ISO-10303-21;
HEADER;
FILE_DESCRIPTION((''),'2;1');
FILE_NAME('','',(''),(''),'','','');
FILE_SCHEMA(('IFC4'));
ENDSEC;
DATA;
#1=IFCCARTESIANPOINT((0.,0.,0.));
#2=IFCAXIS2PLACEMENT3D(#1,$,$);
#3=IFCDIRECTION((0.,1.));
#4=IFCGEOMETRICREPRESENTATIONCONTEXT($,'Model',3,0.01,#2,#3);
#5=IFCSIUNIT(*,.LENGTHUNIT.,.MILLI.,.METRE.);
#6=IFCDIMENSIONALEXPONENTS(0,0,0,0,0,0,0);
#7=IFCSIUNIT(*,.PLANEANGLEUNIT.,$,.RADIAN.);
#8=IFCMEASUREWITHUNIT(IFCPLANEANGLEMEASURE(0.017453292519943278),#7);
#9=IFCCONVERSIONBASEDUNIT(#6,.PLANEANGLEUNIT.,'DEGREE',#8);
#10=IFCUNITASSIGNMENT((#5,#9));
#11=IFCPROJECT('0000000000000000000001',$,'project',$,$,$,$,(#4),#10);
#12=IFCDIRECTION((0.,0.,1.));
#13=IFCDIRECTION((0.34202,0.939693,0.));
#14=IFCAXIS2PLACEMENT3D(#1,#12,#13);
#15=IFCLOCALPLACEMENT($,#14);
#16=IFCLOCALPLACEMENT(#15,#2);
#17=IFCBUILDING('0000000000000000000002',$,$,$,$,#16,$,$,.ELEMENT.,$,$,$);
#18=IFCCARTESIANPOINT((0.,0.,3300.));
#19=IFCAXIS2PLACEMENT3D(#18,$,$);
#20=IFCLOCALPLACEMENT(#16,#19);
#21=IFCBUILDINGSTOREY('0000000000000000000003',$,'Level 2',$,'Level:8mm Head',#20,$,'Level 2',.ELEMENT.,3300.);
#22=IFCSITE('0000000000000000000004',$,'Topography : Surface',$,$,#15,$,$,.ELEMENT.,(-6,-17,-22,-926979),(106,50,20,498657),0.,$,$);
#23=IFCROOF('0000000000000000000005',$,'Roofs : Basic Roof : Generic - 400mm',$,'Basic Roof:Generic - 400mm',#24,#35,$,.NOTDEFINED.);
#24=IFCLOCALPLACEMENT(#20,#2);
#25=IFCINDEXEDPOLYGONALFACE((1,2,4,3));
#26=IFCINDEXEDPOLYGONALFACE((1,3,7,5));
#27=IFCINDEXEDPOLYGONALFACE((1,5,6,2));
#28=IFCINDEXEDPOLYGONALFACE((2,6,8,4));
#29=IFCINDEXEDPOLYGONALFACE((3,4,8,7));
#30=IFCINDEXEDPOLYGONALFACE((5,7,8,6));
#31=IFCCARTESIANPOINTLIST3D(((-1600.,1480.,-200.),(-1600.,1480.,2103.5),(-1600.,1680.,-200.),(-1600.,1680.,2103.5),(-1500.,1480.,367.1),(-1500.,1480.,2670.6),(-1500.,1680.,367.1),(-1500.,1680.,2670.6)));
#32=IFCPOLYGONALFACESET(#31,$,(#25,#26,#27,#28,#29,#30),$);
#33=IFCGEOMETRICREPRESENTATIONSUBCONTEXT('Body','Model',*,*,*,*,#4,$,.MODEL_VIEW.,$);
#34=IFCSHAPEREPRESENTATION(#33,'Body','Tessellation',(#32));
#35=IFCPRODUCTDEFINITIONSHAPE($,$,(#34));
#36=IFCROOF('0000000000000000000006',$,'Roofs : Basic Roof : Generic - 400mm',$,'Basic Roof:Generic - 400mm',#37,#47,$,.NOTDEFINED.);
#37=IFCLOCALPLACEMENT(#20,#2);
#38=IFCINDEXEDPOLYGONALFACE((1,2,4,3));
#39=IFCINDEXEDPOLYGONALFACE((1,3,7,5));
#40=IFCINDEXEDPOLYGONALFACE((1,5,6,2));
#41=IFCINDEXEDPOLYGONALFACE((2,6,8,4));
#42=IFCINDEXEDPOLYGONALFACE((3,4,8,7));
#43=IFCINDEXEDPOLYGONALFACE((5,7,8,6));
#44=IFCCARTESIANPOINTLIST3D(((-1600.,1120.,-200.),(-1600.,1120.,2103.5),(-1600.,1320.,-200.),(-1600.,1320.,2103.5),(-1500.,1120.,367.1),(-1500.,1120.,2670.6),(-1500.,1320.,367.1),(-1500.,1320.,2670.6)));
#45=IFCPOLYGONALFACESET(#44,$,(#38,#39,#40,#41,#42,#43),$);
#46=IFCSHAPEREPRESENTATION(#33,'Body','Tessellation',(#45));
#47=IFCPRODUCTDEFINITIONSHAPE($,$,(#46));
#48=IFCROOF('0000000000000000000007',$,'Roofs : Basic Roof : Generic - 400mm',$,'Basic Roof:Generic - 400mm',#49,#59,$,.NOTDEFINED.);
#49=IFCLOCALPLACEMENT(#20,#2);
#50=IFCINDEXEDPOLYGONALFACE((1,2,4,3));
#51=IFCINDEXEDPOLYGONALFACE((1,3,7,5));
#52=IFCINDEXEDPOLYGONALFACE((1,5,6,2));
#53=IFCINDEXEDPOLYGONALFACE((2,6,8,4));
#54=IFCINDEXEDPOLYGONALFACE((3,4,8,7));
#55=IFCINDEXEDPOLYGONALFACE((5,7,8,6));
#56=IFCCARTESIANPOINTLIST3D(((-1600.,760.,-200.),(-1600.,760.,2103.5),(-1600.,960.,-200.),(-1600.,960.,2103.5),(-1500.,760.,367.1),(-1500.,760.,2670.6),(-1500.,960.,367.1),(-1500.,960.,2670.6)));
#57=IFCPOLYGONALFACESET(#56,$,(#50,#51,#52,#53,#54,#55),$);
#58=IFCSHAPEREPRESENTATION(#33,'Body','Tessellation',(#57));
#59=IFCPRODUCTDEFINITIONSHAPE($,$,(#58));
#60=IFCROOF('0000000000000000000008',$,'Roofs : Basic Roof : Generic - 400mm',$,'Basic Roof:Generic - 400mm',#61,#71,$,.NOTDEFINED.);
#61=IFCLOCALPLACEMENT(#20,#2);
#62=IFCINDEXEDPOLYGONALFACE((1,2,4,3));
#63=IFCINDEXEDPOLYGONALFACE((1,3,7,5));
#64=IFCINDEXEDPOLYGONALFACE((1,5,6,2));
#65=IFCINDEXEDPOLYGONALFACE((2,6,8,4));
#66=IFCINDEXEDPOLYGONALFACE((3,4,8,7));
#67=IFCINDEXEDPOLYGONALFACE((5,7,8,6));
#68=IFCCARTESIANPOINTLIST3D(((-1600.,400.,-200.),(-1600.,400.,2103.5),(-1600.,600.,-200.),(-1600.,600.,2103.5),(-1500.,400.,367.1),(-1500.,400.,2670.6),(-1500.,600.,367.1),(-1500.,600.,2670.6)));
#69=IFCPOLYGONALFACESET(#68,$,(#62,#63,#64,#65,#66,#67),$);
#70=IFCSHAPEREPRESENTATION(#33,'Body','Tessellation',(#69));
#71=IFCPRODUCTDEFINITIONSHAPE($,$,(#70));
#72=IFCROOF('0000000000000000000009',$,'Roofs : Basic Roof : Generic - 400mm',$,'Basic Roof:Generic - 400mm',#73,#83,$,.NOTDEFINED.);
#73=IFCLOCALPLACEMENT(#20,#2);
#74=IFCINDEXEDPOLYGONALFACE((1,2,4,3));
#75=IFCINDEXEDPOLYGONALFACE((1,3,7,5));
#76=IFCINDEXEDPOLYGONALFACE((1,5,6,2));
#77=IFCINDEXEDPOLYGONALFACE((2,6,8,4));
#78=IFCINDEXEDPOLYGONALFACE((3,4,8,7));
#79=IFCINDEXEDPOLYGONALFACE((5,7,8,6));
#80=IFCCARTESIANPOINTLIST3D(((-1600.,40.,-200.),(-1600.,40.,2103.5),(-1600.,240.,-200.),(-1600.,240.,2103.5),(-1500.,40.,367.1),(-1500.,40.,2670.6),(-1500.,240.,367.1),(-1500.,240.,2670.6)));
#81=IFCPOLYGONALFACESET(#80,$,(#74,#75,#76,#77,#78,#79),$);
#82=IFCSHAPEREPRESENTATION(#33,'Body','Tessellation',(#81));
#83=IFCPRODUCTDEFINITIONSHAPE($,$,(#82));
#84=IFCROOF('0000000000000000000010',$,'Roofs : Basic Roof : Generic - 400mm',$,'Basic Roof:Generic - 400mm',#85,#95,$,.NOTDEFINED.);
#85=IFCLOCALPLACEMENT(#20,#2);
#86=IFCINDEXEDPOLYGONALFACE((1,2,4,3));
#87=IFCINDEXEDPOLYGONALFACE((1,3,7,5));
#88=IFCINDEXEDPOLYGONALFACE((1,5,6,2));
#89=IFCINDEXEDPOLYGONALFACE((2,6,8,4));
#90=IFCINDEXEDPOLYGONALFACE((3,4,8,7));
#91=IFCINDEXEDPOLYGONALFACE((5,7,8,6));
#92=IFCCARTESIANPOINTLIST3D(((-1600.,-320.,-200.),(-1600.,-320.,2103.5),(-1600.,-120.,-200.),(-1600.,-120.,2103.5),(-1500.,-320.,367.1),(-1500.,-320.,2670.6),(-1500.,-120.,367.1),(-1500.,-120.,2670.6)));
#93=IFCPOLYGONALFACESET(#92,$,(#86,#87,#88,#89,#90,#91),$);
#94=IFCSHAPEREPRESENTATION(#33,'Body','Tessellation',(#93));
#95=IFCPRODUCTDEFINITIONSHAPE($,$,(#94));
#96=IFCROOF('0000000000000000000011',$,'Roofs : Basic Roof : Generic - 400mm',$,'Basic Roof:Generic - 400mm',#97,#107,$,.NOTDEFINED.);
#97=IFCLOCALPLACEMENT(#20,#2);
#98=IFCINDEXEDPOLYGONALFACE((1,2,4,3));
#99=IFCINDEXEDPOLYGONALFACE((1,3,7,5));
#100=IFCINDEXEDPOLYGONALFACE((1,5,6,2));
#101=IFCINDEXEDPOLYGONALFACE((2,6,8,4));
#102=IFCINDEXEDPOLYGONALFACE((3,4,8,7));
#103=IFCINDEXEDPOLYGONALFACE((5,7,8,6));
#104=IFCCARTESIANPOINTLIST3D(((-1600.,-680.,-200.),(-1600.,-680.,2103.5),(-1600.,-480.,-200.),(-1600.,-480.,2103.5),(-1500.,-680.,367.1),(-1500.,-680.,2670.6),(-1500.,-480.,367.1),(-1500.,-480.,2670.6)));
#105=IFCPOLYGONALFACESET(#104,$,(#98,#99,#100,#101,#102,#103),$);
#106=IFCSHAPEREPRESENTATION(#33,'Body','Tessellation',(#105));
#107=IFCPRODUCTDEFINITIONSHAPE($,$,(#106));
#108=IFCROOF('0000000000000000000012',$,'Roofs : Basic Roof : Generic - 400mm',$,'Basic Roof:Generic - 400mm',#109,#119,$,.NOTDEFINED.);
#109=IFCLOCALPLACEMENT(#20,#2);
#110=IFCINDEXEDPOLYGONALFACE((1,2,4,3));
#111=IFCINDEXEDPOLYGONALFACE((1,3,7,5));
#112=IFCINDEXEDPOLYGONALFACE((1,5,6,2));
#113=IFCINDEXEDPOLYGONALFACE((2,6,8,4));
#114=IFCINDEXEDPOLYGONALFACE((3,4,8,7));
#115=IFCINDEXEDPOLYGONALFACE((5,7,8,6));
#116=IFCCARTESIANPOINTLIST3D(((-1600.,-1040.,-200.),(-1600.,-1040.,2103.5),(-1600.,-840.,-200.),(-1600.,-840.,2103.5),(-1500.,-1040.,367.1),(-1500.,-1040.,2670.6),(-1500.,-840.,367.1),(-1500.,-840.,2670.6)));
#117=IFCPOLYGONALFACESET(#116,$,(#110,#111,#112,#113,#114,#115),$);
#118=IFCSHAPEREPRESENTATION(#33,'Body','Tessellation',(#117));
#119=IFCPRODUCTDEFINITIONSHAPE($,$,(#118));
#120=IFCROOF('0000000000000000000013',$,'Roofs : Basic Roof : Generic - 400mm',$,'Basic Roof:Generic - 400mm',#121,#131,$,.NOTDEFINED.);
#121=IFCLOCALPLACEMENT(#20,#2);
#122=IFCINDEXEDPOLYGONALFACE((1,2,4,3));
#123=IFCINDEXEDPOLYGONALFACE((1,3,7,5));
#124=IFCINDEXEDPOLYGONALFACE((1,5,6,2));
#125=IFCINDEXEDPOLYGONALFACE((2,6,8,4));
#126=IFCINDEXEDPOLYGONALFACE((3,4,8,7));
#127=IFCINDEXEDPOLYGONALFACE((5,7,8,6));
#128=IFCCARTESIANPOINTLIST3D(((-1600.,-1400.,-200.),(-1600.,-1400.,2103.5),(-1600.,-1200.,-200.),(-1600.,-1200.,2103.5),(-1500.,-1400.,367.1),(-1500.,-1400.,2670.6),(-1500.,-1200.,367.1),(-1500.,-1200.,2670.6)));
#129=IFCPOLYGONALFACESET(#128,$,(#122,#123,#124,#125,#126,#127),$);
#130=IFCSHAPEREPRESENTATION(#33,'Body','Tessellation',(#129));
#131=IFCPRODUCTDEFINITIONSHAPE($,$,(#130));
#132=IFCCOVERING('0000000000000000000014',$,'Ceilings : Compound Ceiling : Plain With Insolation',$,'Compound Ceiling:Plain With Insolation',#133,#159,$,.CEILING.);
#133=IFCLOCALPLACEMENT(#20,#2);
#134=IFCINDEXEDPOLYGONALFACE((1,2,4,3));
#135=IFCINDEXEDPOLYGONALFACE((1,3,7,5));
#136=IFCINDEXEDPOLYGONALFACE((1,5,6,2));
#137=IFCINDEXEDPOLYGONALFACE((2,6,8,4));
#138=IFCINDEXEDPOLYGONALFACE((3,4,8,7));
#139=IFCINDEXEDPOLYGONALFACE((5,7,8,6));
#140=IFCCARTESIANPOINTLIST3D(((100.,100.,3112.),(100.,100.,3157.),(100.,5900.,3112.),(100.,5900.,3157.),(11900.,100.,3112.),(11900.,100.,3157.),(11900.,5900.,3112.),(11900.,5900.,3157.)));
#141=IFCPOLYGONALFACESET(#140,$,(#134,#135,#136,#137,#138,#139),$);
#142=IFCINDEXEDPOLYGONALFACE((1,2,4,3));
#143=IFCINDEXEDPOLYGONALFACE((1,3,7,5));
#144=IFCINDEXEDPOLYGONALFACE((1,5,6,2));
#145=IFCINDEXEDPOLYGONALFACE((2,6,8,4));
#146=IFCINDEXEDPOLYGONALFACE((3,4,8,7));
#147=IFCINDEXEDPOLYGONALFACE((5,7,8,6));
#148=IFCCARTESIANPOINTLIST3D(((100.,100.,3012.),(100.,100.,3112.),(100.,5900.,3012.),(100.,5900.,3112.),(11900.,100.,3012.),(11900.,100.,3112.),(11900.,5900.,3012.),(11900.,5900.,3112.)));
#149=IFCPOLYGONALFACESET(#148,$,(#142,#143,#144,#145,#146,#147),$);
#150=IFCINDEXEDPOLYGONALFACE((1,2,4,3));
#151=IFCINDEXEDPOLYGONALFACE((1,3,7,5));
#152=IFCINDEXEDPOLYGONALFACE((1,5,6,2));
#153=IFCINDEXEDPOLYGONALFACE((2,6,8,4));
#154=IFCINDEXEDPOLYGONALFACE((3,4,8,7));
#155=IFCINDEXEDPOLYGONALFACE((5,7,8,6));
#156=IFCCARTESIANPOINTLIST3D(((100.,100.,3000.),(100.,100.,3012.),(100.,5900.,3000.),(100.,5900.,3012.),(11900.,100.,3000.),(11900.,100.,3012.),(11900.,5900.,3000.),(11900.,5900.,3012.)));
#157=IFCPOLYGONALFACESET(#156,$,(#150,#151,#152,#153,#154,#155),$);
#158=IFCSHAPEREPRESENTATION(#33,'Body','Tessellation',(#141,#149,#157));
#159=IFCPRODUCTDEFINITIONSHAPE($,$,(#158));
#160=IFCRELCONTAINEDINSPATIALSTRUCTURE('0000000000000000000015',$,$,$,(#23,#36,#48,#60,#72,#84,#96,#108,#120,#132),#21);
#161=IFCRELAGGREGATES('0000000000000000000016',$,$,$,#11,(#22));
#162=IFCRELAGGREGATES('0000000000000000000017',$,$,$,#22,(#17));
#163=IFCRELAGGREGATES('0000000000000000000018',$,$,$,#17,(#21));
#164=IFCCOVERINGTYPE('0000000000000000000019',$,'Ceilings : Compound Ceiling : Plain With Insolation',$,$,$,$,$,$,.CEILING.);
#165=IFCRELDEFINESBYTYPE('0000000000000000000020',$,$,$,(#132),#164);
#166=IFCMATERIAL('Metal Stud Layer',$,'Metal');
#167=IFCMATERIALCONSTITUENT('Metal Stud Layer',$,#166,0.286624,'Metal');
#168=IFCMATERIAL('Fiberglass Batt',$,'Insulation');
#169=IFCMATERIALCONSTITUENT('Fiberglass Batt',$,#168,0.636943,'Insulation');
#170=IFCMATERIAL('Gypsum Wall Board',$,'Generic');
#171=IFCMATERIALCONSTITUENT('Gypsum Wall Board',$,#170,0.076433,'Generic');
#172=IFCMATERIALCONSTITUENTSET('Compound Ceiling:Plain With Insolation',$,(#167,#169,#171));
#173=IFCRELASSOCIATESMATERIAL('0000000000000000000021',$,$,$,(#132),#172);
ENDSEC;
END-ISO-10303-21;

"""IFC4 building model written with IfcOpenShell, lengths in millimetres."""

from ifc_helpers import new_model, entity, si_unit, converted_unit, direction, frame, origin, place, context, subcontext, project, spatial, indexed_curve, outline, extrude, material, constituent, constituent_set, type_object, element, save


model = new_model("IFC4")

# Units and contexts
model_context = context("Model", 3, precision=0.01, world=origin(), true_north=direction((0.0, 1.0)))
body_context = subcontext(model_context, "Body", "Model", "MODEL_VIEW")
ifc_project = project(units=[si_unit("LENGTHUNIT", "METRE", prefix="MILLI"), converted_unit("PLANEANGLEUNIT", "DEGREE", entity("IfcPlaneAngleMeasure", 0.017453292519943278), si_unit("PLANEANGLEUNIT", "RADIAN"), dimensions=[0, 0, 0, 0, 0, 0, 0])], contexts=[model_context])

# Site, building, storey
site_placement = place(None, frame((0.0, 0.0, 0.0), z_axis=(0.0, 0.0, 1.0), x_axis=(0.34202, 0.939693, 0.0)))
site = spatial("IfcSite", under=ifc_project, at=site_placement, Name="Topography : Surface", CompositionType="ELEMENT", RefLatitude=(-6, -17, -22, -926979), RefLongitude=(106, 50, 20, 498657), RefElevation=0.0)
building_placement = place(site_placement, origin())
building = spatial("IfcBuilding", under=site, at=building_placement, CompositionType="ELEMENT")
storey_placement = place(building_placement, frame((0.0, 0.0, 3300.0)))
storey = spatial("IfcBuildingStorey", under=building, at=storey_placement, Name="Level 2", ObjectType="Level:8mm Head", LongName="Level 2", CompositionType="ELEMENT", Elevation=3300.0)

# Roofs
roof_1_placement = place(storey_placement, frame((-1600.0, 1480.0, -200.0)))
element("IfcRoof", 1, at=roof_1_placement, inside=storey, Name="Roofs : Basic Roof : Generic - 400mm", ObjectType="Basic Roof:Generic - 400mm", PredefinedType="NOTDEFINED", context=body_context, shape_type="SweptSolid", body=[
    extrude(outline(indexed_curve([(-287.9, 100.0), (-287.9, -100.0), (287.9, -100.0), (287.9, 100.0), (-287.9, 100.0)], self_intersect=False)), frame((50.0, 100.0, 283.6), z_axis=(-0.984808, 0.0, 0.173648), x_axis=(0.173648, 0.0, 0.984808)), (0.984808, 0.0, 0.173648), 2303.5),
])
roof_2_placement = place(storey_placement, frame((-1600.0, 1120.0, -200.0)))
element("IfcRoof", 2, at=roof_2_placement, inside=storey, Name="Roofs : Basic Roof : Generic - 400mm", ObjectType="Basic Roof:Generic - 400mm", PredefinedType="NOTDEFINED", context=body_context, shape_type="SweptSolid", body=[
    extrude(outline(indexed_curve([(-287.9, 100.0), (-287.9, -100.0), (287.9, -100.0), (287.9, 100.0), (-287.9, 100.0)], self_intersect=False)), frame((50.0, 100.0, 283.6), z_axis=(-0.984808, 0.0, 0.173648), x_axis=(0.173648, 0.0, 0.984808)), (0.984808, 0.0, 0.173648), 2303.5),
])
roof_3_placement = place(storey_placement, frame((-1600.0, 760.0, -200.0)))
element("IfcRoof", 3, at=roof_3_placement, inside=storey, Name="Roofs : Basic Roof : Generic - 400mm", ObjectType="Basic Roof:Generic - 400mm", PredefinedType="NOTDEFINED", context=body_context, shape_type="SweptSolid", body=[
    extrude(outline(indexed_curve([(-287.9, 100.0), (-287.9, -100.0), (287.9, -100.0), (287.9, 100.0), (-287.9, 100.0)], self_intersect=False)), frame((50.0, 100.0, 283.6), z_axis=(-0.984808, 0.0, 0.173648), x_axis=(0.173648, 0.0, 0.984808)), (0.984808, 0.0, 0.173648), 2303.5),
])
roof_4_placement = place(storey_placement, frame((-1600.0, 400.0, -200.0)))
element("IfcRoof", 4, at=roof_4_placement, inside=storey, Name="Roofs : Basic Roof : Generic - 400mm", ObjectType="Basic Roof:Generic - 400mm", PredefinedType="NOTDEFINED", context=body_context, shape_type="SweptSolid", body=[
    extrude(outline(indexed_curve([(-287.9, 100.0), (-287.9, -100.0), (287.9, -100.0), (287.9, 100.0), (-287.9, 100.0)], self_intersect=False)), frame((50.0, 100.0, 283.6), z_axis=(-0.984808, 0.0, 0.173648), x_axis=(0.173648, 0.0, 0.984808)), (0.984808, 0.0, 0.173648), 2303.5),
])
roof_5_placement = place(storey_placement, frame((-1600.0, 40.0, -200.0)))
element("IfcRoof", 5, at=roof_5_placement, inside=storey, Name="Roofs : Basic Roof : Generic - 400mm", ObjectType="Basic Roof:Generic - 400mm", PredefinedType="NOTDEFINED", context=body_context, shape_type="SweptSolid", body=[
    extrude(outline(indexed_curve([(-287.9, 100.0), (-287.9, -100.0), (287.9, -100.0), (287.9, 100.0), (-287.9, 100.0)], self_intersect=False)), frame((50.0, 100.0, 283.6), z_axis=(-0.984808, 0.0, 0.173648), x_axis=(0.173648, 0.0, 0.984808)), (0.984808, 0.0, 0.173648), 2303.5),
])
roof_6_placement = place(storey_placement, frame((-1600.0, -320.0, -200.0)))
element("IfcRoof", 6, at=roof_6_placement, inside=storey, Name="Roofs : Basic Roof : Generic - 400mm", ObjectType="Basic Roof:Generic - 400mm", PredefinedType="NOTDEFINED", context=body_context, shape_type="SweptSolid", body=[
    extrude(outline(indexed_curve([(-287.9, 100.0), (-287.9, -100.0), (287.9, -100.0), (287.9, 100.0), (-287.9, 100.0)], self_intersect=False)), frame((50.0, 100.0, 283.6), z_axis=(-0.984808, 0.0, 0.173648), x_axis=(0.173648, 0.0, 0.984808)), (0.984808, 0.0, 0.173648), 2303.5),
])
roof_7_placement = place(storey_placement, frame((-1600.0, -680.0, -200.0)))
element("IfcRoof", 7, at=roof_7_placement, inside=storey, Name="Roofs : Basic Roof : Generic - 400mm", ObjectType="Basic Roof:Generic - 400mm", PredefinedType="NOTDEFINED", context=body_context, shape_type="SweptSolid", body=[
    extrude(outline(indexed_curve([(-287.9, 100.0), (-287.9, -100.0), (287.9, -100.0), (287.9, 100.0), (-287.9, 100.0)], self_intersect=False)), frame((50.0, 100.0, 283.6), z_axis=(-0.984808, 0.0, 0.173648), x_axis=(0.173648, 0.0, 0.984808)), (0.984808, 0.0, 0.173648), 2303.5),
])
roof_8_placement = place(storey_placement, frame((-1600.0, -1040.0, -200.0)))
element("IfcRoof", 8, at=roof_8_placement, inside=storey, Name="Roofs : Basic Roof : Generic - 400mm", ObjectType="Basic Roof:Generic - 400mm", PredefinedType="NOTDEFINED", context=body_context, shape_type="SweptSolid", body=[
    extrude(outline(indexed_curve([(-287.9, 100.0), (-287.9, -100.0), (287.9, -100.0), (287.9, 100.0), (-287.9, 100.0)], self_intersect=False)), frame((50.0, 100.0, 283.6), z_axis=(-0.984808, 0.0, 0.173648), x_axis=(0.173648, 0.0, 0.984808)), (0.984808, 0.0, 0.173648), 2303.5),
])
roof_9_placement = place(storey_placement, frame((-1600.0, -1400.0, -200.0)))
element("IfcRoof", 9, at=roof_9_placement, inside=storey, Name="Roofs : Basic Roof : Generic - 400mm", ObjectType="Basic Roof:Generic - 400mm", PredefinedType="NOTDEFINED", context=body_context, shape_type="SweptSolid", body=[
    extrude(outline(indexed_curve([(-287.9, 100.0), (-287.9, -100.0), (287.9, -100.0), (287.9, 100.0), (-287.9, 100.0)], self_intersect=False)), frame((50.0, 100.0, 283.6), z_axis=(-0.984808, 0.0, 0.173648), x_axis=(0.173648, 0.0, 0.984808)), (0.984808, 0.0, 0.173648), 2303.5),
])

# Covering
ifc_material_1 = material(Name="Metal Stud Layer", Category="Metal")
ifc_constituent_1 = constituent(ifc_material_1, Name="Metal Stud Layer", Category="Metal", fraction=0.286624)
ifc_material_2 = material(Name="Fiberglass Batt", Category="Insulation")
ifc_constituent_2 = constituent(ifc_material_2, Name="Fiberglass Batt", Category="Insulation", fraction=0.636943)
ifc_material_3 = material(Name="Gypsum Wall Board", Category="Generic")
ifc_constituent_3 = constituent(ifc_material_3, Name="Gypsum Wall Board", Category="Generic", fraction=0.076433)
ifc_constituent_set_1 = constituent_set(constituents=[ifc_constituent_1, ifc_constituent_2, ifc_constituent_3], Name="Compound Ceiling:Plain With Insolation")
covering_type = type_object("IfcCoveringType", Name="Ceilings : Compound Ceiling : Plain With Insolation", PredefinedType="CEILING")
covering_placement = place(storey_placement, frame((100.0, 100.0, 3000.0)))
element("IfcCovering", 10, at=covering_placement, inside=storey, type_object=covering_type, material=ifc_constituent_set_1, Name="Ceilings : Compound Ceiling : Plain With Insolation", ObjectType="Compound Ceiling:Plain With Insolation", PredefinedType="CEILING", context=body_context, shape_type="SweptSolid", body=[
    extrude(outline(indexed_curve([(-2900.0, -5900.0), (2900.0, -5900.0), (2900.0, 5900.0), (-2900.0, 5900.0), (-2900.0, -5900.0)], self_intersect=False)), frame((5900.0, 2900.0, 112.0), z_axis=(0.0, 0.0, 1.0), x_axis=(0.0, -1.0, 0.0)), (0.0, 0.0, 1.0), 45.0),
    extrude(outline(indexed_curve([(-2900.0, -5900.0), (2900.0, -5900.0), (2900.0, 5900.0), (-2900.0, 5900.0), (-2900.0, -5900.0)], self_intersect=False)), frame((5900.0, 2900.0, 12.0), z_axis=(0.0, 0.0, 1.0), x_axis=(0.0, -1.0, 0.0)), (0.0, 0.0, 1.0), 100.0),
    extrude(outline(indexed_curve([(-5900.0, -2900.0), (5900.0, -2900.0), (5900.0, 2900.0), (-5900.0, 2900.0), (-5900.0, -2900.0)], self_intersect=False)), frame((5900.0, 2900.0, 0.0), z_axis=(0.0, 0.0, 1.0), x_axis=(-1.0, 0.0, 0.0)), (0.0, 0.0, 1.0), 12.0),
])

save(model, "model.ifc")
